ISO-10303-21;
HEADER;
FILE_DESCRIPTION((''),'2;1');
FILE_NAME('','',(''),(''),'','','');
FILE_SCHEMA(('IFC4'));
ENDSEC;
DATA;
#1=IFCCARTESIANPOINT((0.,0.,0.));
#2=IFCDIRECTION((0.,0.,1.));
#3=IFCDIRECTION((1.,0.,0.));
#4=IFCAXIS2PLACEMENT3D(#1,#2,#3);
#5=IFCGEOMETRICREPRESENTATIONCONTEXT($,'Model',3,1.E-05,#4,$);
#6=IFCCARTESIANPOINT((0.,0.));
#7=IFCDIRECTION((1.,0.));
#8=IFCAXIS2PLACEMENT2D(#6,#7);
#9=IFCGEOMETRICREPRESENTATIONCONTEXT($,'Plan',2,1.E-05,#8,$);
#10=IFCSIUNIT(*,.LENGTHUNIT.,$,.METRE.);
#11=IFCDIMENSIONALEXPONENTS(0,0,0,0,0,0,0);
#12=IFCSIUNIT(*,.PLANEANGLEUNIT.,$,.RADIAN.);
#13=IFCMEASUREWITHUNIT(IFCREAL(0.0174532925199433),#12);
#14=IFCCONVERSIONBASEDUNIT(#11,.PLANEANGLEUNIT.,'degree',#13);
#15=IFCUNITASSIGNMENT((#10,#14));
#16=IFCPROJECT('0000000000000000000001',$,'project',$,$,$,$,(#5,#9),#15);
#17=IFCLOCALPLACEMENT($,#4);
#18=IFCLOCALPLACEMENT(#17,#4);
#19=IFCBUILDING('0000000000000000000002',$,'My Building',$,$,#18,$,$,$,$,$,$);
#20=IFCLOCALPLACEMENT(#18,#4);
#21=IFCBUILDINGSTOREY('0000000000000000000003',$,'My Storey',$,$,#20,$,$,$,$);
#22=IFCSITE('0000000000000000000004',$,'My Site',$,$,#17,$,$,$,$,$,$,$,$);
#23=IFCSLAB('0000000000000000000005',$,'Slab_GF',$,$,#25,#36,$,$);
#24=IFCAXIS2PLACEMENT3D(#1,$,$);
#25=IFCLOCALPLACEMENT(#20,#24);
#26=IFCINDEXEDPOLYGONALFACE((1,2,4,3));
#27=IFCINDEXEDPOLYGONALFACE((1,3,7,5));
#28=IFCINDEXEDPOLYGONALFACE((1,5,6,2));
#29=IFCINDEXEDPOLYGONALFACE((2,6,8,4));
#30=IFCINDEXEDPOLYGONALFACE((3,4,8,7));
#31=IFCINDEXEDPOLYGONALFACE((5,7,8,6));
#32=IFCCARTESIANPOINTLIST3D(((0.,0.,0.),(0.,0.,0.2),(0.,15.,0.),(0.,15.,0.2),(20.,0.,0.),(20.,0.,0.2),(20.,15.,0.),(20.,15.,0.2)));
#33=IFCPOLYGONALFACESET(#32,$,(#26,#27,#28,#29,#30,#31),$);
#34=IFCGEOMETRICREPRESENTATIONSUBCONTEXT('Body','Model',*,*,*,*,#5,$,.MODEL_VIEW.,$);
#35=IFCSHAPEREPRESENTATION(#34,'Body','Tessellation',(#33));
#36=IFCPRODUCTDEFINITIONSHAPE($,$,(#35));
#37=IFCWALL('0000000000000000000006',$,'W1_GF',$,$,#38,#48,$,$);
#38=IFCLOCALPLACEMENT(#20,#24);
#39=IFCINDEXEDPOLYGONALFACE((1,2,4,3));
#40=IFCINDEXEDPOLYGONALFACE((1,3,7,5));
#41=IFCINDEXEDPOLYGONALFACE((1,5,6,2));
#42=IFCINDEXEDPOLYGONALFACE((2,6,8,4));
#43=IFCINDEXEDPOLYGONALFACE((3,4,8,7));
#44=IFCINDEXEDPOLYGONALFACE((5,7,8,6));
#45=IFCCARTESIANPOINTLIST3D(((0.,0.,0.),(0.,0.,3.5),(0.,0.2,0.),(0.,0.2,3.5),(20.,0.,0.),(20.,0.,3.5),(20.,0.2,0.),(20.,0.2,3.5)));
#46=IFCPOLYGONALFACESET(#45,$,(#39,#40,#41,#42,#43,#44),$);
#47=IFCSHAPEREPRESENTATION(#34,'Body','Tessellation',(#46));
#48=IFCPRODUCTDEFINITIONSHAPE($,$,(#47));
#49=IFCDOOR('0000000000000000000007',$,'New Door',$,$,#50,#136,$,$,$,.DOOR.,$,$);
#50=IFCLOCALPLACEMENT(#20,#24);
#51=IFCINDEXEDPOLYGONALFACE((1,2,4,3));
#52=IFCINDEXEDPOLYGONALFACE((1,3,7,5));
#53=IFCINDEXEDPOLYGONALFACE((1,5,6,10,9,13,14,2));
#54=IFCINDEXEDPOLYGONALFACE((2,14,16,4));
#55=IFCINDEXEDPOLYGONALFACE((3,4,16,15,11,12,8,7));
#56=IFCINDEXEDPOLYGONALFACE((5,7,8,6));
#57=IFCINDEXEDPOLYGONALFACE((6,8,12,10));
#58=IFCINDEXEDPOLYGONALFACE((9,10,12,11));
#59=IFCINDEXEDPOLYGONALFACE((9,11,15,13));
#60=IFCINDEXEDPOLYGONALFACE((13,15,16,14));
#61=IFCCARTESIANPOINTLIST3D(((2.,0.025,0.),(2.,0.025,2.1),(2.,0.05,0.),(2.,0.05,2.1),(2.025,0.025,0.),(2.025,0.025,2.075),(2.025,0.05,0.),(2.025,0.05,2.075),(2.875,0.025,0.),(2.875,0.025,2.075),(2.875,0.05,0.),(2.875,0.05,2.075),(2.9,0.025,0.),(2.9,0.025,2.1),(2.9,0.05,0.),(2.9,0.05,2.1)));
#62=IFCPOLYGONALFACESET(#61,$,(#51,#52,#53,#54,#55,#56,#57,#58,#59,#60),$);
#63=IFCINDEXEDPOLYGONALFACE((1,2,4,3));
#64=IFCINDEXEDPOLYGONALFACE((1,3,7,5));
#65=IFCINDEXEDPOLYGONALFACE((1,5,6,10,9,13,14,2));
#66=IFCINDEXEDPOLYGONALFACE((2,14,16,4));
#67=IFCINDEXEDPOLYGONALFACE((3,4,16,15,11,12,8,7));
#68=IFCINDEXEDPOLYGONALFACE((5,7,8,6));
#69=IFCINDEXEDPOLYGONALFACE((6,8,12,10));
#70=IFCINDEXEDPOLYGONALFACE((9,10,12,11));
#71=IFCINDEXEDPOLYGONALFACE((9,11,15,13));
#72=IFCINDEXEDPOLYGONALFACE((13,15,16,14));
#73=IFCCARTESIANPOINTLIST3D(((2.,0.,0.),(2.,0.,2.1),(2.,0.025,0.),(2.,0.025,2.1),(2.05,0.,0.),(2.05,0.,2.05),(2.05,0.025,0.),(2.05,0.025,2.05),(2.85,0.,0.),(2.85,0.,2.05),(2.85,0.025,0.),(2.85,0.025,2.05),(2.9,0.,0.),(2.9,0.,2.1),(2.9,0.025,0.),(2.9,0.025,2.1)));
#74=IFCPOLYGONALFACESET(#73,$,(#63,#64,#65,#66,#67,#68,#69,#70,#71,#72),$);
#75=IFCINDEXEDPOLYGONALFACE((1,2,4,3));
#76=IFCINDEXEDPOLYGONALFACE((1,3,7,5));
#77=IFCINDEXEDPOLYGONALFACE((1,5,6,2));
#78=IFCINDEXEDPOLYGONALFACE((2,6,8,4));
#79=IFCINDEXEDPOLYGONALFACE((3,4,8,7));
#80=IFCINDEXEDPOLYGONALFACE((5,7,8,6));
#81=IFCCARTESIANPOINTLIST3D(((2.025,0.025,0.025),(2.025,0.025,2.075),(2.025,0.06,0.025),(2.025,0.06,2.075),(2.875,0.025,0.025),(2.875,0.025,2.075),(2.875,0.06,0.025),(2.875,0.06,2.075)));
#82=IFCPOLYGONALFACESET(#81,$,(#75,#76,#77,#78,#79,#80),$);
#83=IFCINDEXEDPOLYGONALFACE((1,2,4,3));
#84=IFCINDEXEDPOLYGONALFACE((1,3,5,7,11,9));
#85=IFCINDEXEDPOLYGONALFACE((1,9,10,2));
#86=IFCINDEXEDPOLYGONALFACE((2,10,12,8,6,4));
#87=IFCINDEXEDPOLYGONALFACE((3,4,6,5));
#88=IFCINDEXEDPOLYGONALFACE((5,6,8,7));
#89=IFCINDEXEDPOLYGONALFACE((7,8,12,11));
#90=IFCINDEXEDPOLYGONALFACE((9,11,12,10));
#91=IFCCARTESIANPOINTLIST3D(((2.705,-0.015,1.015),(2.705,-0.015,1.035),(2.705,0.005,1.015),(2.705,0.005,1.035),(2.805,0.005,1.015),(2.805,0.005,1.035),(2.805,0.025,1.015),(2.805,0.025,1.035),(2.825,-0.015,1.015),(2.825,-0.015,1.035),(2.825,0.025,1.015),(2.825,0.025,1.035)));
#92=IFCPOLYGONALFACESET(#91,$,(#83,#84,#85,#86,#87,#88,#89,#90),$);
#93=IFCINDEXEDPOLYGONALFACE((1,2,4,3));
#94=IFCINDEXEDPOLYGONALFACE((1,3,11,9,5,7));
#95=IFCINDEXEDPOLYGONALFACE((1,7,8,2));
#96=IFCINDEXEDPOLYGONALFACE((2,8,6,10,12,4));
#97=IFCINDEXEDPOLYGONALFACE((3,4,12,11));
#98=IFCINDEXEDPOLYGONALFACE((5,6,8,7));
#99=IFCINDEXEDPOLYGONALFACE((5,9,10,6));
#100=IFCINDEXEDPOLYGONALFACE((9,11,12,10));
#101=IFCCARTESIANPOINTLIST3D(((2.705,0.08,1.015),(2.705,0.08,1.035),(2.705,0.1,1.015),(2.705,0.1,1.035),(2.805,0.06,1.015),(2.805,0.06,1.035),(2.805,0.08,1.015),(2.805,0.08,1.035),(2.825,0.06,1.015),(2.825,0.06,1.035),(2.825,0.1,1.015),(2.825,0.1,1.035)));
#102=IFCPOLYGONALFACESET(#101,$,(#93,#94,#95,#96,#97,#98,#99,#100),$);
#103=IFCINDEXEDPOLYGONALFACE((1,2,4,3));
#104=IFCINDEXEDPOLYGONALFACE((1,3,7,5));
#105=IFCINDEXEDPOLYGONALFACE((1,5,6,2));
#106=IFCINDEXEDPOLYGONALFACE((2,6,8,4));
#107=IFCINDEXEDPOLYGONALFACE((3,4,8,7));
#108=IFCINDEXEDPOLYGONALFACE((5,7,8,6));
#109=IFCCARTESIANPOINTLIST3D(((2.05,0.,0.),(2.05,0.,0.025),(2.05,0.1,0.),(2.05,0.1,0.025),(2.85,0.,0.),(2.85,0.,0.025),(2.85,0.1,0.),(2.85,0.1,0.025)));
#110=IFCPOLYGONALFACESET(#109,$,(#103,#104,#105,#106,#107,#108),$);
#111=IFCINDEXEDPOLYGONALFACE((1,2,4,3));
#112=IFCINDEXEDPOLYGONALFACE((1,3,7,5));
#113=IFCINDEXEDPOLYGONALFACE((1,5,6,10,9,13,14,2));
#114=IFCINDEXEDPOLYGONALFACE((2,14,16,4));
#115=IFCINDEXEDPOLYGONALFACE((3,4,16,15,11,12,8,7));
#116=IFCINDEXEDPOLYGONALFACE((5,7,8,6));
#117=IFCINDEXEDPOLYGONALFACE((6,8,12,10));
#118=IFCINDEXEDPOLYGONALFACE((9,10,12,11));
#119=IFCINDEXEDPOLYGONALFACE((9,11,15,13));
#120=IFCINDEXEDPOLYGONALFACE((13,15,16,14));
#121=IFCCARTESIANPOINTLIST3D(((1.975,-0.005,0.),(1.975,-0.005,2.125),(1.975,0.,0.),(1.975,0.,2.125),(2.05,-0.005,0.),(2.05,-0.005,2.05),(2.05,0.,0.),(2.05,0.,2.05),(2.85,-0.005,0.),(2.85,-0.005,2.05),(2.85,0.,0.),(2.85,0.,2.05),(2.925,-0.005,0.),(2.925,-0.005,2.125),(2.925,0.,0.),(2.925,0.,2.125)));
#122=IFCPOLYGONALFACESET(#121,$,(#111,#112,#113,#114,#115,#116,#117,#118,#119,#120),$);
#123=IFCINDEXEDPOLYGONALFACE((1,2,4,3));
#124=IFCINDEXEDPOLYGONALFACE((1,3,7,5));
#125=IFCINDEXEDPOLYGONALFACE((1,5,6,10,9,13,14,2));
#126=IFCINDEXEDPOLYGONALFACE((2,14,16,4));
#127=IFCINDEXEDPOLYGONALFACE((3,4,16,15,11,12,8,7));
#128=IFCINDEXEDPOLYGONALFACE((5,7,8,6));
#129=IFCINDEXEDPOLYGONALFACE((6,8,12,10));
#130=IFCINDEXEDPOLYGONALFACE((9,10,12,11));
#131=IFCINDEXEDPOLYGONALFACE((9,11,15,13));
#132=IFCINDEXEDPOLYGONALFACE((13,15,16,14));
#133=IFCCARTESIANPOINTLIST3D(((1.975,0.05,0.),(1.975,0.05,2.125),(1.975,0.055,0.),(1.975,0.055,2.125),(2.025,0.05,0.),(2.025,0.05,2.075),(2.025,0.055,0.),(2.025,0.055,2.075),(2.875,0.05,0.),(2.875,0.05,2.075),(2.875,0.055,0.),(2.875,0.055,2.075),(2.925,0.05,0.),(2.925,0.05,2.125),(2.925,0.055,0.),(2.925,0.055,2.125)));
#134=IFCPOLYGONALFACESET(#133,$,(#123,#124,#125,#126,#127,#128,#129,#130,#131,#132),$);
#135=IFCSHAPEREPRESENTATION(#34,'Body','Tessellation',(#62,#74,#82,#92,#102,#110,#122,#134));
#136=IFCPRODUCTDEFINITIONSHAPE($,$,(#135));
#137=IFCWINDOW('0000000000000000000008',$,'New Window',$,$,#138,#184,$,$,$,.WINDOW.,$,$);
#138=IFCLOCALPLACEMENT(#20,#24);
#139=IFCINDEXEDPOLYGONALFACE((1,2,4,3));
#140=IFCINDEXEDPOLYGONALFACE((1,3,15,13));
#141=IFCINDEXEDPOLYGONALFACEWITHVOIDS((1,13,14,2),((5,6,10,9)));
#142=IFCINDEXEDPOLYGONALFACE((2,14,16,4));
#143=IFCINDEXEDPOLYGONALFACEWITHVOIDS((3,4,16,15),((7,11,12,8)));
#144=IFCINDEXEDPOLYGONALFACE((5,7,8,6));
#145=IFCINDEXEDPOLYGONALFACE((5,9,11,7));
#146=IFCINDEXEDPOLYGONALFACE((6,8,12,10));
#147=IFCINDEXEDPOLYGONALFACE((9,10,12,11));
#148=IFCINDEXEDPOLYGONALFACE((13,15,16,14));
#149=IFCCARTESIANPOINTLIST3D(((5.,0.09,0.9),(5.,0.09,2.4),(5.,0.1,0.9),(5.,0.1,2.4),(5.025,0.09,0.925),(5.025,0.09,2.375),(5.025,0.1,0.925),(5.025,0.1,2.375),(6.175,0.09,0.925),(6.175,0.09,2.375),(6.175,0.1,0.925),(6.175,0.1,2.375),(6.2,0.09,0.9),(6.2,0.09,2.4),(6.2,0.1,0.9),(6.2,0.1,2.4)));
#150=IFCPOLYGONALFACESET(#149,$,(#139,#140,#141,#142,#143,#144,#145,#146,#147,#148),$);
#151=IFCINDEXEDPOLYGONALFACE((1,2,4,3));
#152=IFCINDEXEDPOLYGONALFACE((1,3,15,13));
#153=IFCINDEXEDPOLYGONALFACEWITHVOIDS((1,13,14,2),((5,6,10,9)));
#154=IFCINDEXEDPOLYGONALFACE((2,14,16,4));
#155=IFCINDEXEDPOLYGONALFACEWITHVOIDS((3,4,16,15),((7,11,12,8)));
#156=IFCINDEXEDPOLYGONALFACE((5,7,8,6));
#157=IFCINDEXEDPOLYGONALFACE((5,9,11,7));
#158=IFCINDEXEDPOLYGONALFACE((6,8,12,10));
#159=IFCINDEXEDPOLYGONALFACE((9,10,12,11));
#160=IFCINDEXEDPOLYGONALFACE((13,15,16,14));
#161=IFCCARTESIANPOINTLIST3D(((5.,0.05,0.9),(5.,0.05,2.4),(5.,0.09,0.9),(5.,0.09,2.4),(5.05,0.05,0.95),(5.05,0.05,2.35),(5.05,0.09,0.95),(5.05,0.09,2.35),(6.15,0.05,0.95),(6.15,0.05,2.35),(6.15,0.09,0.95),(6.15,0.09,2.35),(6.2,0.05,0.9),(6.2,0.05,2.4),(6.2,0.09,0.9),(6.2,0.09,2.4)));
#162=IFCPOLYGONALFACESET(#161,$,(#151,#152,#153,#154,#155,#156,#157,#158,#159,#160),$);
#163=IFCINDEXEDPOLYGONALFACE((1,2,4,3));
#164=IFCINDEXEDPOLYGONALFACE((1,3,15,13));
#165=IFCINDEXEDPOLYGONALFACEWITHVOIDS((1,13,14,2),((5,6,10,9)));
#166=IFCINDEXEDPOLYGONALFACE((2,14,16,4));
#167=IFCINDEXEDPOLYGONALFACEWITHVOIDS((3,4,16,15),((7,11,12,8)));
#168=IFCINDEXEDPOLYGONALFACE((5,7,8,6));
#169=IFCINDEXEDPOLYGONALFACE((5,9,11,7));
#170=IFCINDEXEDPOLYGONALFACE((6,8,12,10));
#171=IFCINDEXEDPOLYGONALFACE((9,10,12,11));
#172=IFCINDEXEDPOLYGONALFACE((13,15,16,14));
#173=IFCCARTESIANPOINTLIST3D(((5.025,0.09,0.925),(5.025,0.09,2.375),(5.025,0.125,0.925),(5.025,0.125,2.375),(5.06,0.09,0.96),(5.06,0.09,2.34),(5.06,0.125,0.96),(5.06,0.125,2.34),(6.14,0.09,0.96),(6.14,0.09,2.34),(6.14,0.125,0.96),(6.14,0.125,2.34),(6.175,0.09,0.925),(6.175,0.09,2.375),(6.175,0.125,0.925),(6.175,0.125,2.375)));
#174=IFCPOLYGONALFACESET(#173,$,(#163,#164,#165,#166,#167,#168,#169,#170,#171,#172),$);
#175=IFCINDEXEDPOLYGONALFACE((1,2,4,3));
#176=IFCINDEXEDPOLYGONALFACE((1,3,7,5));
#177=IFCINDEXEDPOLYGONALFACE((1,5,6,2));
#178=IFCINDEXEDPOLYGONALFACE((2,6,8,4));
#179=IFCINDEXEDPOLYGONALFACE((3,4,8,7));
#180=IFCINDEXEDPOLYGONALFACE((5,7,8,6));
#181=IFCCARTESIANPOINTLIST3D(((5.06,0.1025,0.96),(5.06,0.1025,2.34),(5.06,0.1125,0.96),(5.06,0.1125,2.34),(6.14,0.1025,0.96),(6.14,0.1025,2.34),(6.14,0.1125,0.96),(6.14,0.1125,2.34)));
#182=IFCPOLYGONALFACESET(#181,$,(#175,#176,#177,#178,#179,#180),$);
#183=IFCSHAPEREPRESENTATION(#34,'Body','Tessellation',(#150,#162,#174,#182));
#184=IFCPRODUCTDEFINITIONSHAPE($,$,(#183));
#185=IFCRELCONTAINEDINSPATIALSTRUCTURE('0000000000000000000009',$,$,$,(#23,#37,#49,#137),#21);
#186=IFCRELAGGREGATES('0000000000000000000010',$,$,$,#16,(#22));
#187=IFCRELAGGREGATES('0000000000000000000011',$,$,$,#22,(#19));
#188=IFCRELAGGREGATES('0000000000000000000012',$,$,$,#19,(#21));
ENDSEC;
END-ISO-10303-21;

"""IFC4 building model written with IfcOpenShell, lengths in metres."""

from ifc_helpers import new_model, entity, si_unit, converted_unit, frame, origin_with_axes, origin_2d_with_axis, place, context, subcontext, project, spatial, line, indexed_curve, outline, extrude, element, save


model = new_model("IFC4")

# Units and contexts
model_context = context("Model", 3, precision=1e-05, world=origin_with_axes())
plan_context = context("Plan", 2, precision=1e-05, world=origin_2d_with_axis())
body_context = subcontext(model_context, "Body", "Model", "MODEL_VIEW")
ifc_project = project(units=[si_unit("LENGTHUNIT", "METRE"), converted_unit("PLANEANGLEUNIT", "degree", entity("IfcReal", 0.0174532925199433), si_unit("PLANEANGLEUNIT", "RADIAN"), dimensions=[0, 0, 0, 0, 0, 0, 0])], contexts=[model_context, plan_context])

# Site, building, storey
site_placement = place(None, origin_with_axes())
site = spatial("IfcSite", under=ifc_project, at=site_placement, Name="My Site")
building_placement = place(site_placement, origin_with_axes())
building = spatial("IfcBuilding", under=site, at=building_placement, Name="My Building")
storey_placement = place(building_placement, origin_with_axes())
storey = spatial("IfcBuildingStorey", under=building, at=storey_placement, Name="My Storey")

# Slab
for number, where, z_axis, x_axis, name in (
    (1, (0.0, 0.0, 0.0), (0.0, 0.0, 1.0), (1.0, 0.0, 0.0), "Slab_GF"),
):
    element("IfcSlab", number, at=place(storey_placement, frame(where, z_axis=z_axis, x_axis=x_axis)), inside=storey, Name=name, context=body_context, shape_type="SweptSolid", body=[
        extrude(outline(indexed_curve([(0.0, 0.0), (20.0, 0.0), (20.0, 15.0), (0.0, 15.0), (0.0, 0.0)])), None, (0.0, 0.0, 1.0), 0.2),
    ])

# Wall
for number, where, z_axis, x_axis, name in (
    (2, (0.0, 0.0, 0.0), (0.0, 0.0, 1.0), (1.0, 0.0, 0.0), "W1_GF"),
):
    element("IfcWall", number, at=place(storey_placement, frame(where, z_axis=z_axis, x_axis=x_axis)), inside=storey, Name=name, context=body_context, shape_type="SweptSolid", body=[
        extrude(outline(indexed_curve([(0.0, 0.0), (0.0, 0.2), (20.0, 0.2), (20.0, 0.0), (0.0, 0.0)], self_intersect=False)), origin_with_axes(), (0.0, 0.0, 1.0), 3.5),
    ])

# Door
door_1_placement = place(storey_placement, frame((2.0, 0.0, 0.0), z_axis=(0.0, 0.0, 1.0), x_axis=(1.0, 0.0, 0.0)))
element("IfcDoor", 3, at=door_1_placement, inside=storey, Name="New Door", PredefinedType="DOOR", context=body_context, shape_type="SweptSolid", body=[
    extrude(outline(indexed_curve([(0.0, 0.0), (0.0, 2.1), (0.9, 2.1), (0.9, 0.0), (0.875, 0.0), (0.875, 2.075), (0.025, 2.075), (0.025, 0.0)], segments=[line(1, 2, 3, 4, 5, 6, 7, 8, 1)])), frame((0.0, 0.025, 0.0), z_axis=(0.0, -1.0, 0.0), x_axis=(1.0, 0.0, 0.0)), (0.0, 0.0, -1.0), 0.025),
    extrude(outline(indexed_curve([(0.0, 0.0), (0.0, 2.1), (0.9, 2.1), (0.9, 0.0), (0.85, 0.0), (0.85, 2.05), (0.05, 2.05), (0.05, 0.0)], segments=[line(1, 2, 3, 4, 5, 6, 7, 8, 1)])), frame((0.0, 0.0, 0.0), z_axis=(0.0, -1.0, 0.0), x_axis=(1.0, 0.0, 0.0)), (0.0, 0.0, -1.0), 0.025),
    extrude(outline(indexed_curve([(0.0, 0.0), (0.85, 0.0), (0.85, 0.035), (0.0, 0.035)], segments=[line(1, 2, 3, 4, 1)])), frame((0.025, 0.025, 0.025), z_axis=(0.0, 0.0, 1.0), x_axis=(1.0, 0.0, 0.0)), (0.0, 0.0, 1.0), 2.05),
    extrude(outline(indexed_curve([(0.0, 0.0), (0.0, -0.04), (-0.12, -0.04), (-0.12, -0.02), (-0.02, -0.02), (-0.02, 0.0)], segments=[line(1, 2, 3, 4, 5, 6, 1)])), frame((0.825, 0.025, 1.015), z_axis=(0.0, 0.0, 1.0), x_axis=(1.0, 0.0, 0.0)), (0.0, 0.0, 1.0), 0.02),
    extrude(outline(indexed_curve([(0.0, 0.0), (0.0, 0.04), (-0.12, 0.04), (-0.12, 0.02), (-0.02, 0.02), (-0.02, 0.0)], segments=[line(1, 2, 3, 4, 5, 6, 1)])), frame((0.825, 0.06, 1.015), z_axis=(0.0, 0.0, 1.0), x_axis=(1.0, 0.0, 0.0)), (0.0, 0.0, 1.0), 0.02),
    extrude(outline(indexed_curve([(0.0, 0.0), (0.8, 0.0), (0.8, 0.1), (0.0, 0.1)], segments=[line(1, 2, 3, 4, 1)])), frame((0.05, 0.0, 0.0), z_axis=(0.0, 0.0, 1.0), x_axis=(1.0, 0.0, 0.0)), (0.0, 0.0, 1.0), 0.025),
    extrude(outline(indexed_curve([(0.0, 0.0), (0.0, 2.125), (0.95, 2.125), (0.95, 0.0), (0.875, 0.0), (0.875, 2.05), (0.075, 2.05), (0.075, 0.0)], segments=[line(1, 2, 3, 4, 5, 6, 7, 8, 1)])), frame((-0.025, -0.005, 0.0), z_axis=(0.0, -1.0, 0.0), x_axis=(1.0, 0.0, 0.0)), (0.0, 0.0, -1.0), 0.005),
    extrude(outline(indexed_curve([(0.0, 0.0), (0.0, 2.125), (0.95, 2.125), (0.95, 0.0), (0.9, 0.0), (0.9, 2.075), (0.05, 2.075), (0.05, 0.0)], segments=[line(1, 2, 3, 4, 5, 6, 7, 8, 1)])), frame((-0.025, 0.05, 0.0), z_axis=(0.0, -1.0, 0.0), x_axis=(1.0, 0.0, 0.0)), (0.0, 0.0, -1.0), 0.005),
])

# Window
window_placement = place(storey_placement, frame((5.0, 0.0, 0.9), z_axis=(0.0, 0.0, 1.0), x_axis=(1.0, 0.0, 0.0)))
element("IfcWindow", 4, at=window_placement, inside=storey, Name="New Window", PredefinedType="WINDOW", context=body_context, shape_type="SweptSolid", body=[
    extrude(outline(indexed_curve([(0.0, 0.0), (1.2, 0.0), (1.2, 1.5), (0.0, 1.5)], segments=[line(1, 2, 3, 4, 1)]), holes=[indexed_curve([(0.025, 0.025), (1.175, 0.025), (1.175, 1.475), (0.025, 1.475)], segments=[line(1, 2, 3, 4, 1)])]), frame((0.0, 0.09, 0.0), z_axis=(0.0, -1.0, 0.0), x_axis=(1.0, 0.0, 0.0)), (0.0, 0.0, -1.0), 0.01),
    extrude(outline(indexed_curve([(0.0, 0.0), (1.2, 0.0), (1.2, 1.5), (0.0, 1.5)], segments=[line(1, 2, 3, 4, 1)]), holes=[indexed_curve([(0.05, 0.05), (1.15, 0.05), (1.15, 1.45), (0.05, 1.45)], segments=[line(1, 2, 3, 4, 1)])]), frame((0.0, 0.05, 0.0), z_axis=(0.0, -1.0, 0.0), x_axis=(1.0, 0.0, 0.0)), (0.0, 0.0, -1.0), 0.04),
    extrude(outline(indexed_curve([(0.0, 0.0), (1.15, 0.0), (1.15, 1.45), (0.0, 1.45)], segments=[line(1, 2, 3, 4, 1)]), holes=[indexed_curve([(0.035, 0.035), (1.115, 0.035), (1.115, 1.415), (0.035, 1.415)], segments=[line(1, 2, 3, 4, 1)])]), frame((0.025, 0.09, 0.025), z_axis=(0.0, -1.0, 0.0), x_axis=(1.0, 0.0, 0.0)), (0.0, 0.0, -1.0), 0.035),
    extrude(outline(indexed_curve([(0.035, 0.035), (1.115, 0.035), (1.115, 1.415), (0.035, 1.415)], segments=[line(1, 2, 3, 4, 1)])), frame((0.025, 0.1025, 0.025), z_axis=(0.0, -1.0, 0.0), x_axis=(1.0, 0.0, 0.0)), (0.0, 0.0, -1.0), 0.01),
])

save(model, "model.ifc")
